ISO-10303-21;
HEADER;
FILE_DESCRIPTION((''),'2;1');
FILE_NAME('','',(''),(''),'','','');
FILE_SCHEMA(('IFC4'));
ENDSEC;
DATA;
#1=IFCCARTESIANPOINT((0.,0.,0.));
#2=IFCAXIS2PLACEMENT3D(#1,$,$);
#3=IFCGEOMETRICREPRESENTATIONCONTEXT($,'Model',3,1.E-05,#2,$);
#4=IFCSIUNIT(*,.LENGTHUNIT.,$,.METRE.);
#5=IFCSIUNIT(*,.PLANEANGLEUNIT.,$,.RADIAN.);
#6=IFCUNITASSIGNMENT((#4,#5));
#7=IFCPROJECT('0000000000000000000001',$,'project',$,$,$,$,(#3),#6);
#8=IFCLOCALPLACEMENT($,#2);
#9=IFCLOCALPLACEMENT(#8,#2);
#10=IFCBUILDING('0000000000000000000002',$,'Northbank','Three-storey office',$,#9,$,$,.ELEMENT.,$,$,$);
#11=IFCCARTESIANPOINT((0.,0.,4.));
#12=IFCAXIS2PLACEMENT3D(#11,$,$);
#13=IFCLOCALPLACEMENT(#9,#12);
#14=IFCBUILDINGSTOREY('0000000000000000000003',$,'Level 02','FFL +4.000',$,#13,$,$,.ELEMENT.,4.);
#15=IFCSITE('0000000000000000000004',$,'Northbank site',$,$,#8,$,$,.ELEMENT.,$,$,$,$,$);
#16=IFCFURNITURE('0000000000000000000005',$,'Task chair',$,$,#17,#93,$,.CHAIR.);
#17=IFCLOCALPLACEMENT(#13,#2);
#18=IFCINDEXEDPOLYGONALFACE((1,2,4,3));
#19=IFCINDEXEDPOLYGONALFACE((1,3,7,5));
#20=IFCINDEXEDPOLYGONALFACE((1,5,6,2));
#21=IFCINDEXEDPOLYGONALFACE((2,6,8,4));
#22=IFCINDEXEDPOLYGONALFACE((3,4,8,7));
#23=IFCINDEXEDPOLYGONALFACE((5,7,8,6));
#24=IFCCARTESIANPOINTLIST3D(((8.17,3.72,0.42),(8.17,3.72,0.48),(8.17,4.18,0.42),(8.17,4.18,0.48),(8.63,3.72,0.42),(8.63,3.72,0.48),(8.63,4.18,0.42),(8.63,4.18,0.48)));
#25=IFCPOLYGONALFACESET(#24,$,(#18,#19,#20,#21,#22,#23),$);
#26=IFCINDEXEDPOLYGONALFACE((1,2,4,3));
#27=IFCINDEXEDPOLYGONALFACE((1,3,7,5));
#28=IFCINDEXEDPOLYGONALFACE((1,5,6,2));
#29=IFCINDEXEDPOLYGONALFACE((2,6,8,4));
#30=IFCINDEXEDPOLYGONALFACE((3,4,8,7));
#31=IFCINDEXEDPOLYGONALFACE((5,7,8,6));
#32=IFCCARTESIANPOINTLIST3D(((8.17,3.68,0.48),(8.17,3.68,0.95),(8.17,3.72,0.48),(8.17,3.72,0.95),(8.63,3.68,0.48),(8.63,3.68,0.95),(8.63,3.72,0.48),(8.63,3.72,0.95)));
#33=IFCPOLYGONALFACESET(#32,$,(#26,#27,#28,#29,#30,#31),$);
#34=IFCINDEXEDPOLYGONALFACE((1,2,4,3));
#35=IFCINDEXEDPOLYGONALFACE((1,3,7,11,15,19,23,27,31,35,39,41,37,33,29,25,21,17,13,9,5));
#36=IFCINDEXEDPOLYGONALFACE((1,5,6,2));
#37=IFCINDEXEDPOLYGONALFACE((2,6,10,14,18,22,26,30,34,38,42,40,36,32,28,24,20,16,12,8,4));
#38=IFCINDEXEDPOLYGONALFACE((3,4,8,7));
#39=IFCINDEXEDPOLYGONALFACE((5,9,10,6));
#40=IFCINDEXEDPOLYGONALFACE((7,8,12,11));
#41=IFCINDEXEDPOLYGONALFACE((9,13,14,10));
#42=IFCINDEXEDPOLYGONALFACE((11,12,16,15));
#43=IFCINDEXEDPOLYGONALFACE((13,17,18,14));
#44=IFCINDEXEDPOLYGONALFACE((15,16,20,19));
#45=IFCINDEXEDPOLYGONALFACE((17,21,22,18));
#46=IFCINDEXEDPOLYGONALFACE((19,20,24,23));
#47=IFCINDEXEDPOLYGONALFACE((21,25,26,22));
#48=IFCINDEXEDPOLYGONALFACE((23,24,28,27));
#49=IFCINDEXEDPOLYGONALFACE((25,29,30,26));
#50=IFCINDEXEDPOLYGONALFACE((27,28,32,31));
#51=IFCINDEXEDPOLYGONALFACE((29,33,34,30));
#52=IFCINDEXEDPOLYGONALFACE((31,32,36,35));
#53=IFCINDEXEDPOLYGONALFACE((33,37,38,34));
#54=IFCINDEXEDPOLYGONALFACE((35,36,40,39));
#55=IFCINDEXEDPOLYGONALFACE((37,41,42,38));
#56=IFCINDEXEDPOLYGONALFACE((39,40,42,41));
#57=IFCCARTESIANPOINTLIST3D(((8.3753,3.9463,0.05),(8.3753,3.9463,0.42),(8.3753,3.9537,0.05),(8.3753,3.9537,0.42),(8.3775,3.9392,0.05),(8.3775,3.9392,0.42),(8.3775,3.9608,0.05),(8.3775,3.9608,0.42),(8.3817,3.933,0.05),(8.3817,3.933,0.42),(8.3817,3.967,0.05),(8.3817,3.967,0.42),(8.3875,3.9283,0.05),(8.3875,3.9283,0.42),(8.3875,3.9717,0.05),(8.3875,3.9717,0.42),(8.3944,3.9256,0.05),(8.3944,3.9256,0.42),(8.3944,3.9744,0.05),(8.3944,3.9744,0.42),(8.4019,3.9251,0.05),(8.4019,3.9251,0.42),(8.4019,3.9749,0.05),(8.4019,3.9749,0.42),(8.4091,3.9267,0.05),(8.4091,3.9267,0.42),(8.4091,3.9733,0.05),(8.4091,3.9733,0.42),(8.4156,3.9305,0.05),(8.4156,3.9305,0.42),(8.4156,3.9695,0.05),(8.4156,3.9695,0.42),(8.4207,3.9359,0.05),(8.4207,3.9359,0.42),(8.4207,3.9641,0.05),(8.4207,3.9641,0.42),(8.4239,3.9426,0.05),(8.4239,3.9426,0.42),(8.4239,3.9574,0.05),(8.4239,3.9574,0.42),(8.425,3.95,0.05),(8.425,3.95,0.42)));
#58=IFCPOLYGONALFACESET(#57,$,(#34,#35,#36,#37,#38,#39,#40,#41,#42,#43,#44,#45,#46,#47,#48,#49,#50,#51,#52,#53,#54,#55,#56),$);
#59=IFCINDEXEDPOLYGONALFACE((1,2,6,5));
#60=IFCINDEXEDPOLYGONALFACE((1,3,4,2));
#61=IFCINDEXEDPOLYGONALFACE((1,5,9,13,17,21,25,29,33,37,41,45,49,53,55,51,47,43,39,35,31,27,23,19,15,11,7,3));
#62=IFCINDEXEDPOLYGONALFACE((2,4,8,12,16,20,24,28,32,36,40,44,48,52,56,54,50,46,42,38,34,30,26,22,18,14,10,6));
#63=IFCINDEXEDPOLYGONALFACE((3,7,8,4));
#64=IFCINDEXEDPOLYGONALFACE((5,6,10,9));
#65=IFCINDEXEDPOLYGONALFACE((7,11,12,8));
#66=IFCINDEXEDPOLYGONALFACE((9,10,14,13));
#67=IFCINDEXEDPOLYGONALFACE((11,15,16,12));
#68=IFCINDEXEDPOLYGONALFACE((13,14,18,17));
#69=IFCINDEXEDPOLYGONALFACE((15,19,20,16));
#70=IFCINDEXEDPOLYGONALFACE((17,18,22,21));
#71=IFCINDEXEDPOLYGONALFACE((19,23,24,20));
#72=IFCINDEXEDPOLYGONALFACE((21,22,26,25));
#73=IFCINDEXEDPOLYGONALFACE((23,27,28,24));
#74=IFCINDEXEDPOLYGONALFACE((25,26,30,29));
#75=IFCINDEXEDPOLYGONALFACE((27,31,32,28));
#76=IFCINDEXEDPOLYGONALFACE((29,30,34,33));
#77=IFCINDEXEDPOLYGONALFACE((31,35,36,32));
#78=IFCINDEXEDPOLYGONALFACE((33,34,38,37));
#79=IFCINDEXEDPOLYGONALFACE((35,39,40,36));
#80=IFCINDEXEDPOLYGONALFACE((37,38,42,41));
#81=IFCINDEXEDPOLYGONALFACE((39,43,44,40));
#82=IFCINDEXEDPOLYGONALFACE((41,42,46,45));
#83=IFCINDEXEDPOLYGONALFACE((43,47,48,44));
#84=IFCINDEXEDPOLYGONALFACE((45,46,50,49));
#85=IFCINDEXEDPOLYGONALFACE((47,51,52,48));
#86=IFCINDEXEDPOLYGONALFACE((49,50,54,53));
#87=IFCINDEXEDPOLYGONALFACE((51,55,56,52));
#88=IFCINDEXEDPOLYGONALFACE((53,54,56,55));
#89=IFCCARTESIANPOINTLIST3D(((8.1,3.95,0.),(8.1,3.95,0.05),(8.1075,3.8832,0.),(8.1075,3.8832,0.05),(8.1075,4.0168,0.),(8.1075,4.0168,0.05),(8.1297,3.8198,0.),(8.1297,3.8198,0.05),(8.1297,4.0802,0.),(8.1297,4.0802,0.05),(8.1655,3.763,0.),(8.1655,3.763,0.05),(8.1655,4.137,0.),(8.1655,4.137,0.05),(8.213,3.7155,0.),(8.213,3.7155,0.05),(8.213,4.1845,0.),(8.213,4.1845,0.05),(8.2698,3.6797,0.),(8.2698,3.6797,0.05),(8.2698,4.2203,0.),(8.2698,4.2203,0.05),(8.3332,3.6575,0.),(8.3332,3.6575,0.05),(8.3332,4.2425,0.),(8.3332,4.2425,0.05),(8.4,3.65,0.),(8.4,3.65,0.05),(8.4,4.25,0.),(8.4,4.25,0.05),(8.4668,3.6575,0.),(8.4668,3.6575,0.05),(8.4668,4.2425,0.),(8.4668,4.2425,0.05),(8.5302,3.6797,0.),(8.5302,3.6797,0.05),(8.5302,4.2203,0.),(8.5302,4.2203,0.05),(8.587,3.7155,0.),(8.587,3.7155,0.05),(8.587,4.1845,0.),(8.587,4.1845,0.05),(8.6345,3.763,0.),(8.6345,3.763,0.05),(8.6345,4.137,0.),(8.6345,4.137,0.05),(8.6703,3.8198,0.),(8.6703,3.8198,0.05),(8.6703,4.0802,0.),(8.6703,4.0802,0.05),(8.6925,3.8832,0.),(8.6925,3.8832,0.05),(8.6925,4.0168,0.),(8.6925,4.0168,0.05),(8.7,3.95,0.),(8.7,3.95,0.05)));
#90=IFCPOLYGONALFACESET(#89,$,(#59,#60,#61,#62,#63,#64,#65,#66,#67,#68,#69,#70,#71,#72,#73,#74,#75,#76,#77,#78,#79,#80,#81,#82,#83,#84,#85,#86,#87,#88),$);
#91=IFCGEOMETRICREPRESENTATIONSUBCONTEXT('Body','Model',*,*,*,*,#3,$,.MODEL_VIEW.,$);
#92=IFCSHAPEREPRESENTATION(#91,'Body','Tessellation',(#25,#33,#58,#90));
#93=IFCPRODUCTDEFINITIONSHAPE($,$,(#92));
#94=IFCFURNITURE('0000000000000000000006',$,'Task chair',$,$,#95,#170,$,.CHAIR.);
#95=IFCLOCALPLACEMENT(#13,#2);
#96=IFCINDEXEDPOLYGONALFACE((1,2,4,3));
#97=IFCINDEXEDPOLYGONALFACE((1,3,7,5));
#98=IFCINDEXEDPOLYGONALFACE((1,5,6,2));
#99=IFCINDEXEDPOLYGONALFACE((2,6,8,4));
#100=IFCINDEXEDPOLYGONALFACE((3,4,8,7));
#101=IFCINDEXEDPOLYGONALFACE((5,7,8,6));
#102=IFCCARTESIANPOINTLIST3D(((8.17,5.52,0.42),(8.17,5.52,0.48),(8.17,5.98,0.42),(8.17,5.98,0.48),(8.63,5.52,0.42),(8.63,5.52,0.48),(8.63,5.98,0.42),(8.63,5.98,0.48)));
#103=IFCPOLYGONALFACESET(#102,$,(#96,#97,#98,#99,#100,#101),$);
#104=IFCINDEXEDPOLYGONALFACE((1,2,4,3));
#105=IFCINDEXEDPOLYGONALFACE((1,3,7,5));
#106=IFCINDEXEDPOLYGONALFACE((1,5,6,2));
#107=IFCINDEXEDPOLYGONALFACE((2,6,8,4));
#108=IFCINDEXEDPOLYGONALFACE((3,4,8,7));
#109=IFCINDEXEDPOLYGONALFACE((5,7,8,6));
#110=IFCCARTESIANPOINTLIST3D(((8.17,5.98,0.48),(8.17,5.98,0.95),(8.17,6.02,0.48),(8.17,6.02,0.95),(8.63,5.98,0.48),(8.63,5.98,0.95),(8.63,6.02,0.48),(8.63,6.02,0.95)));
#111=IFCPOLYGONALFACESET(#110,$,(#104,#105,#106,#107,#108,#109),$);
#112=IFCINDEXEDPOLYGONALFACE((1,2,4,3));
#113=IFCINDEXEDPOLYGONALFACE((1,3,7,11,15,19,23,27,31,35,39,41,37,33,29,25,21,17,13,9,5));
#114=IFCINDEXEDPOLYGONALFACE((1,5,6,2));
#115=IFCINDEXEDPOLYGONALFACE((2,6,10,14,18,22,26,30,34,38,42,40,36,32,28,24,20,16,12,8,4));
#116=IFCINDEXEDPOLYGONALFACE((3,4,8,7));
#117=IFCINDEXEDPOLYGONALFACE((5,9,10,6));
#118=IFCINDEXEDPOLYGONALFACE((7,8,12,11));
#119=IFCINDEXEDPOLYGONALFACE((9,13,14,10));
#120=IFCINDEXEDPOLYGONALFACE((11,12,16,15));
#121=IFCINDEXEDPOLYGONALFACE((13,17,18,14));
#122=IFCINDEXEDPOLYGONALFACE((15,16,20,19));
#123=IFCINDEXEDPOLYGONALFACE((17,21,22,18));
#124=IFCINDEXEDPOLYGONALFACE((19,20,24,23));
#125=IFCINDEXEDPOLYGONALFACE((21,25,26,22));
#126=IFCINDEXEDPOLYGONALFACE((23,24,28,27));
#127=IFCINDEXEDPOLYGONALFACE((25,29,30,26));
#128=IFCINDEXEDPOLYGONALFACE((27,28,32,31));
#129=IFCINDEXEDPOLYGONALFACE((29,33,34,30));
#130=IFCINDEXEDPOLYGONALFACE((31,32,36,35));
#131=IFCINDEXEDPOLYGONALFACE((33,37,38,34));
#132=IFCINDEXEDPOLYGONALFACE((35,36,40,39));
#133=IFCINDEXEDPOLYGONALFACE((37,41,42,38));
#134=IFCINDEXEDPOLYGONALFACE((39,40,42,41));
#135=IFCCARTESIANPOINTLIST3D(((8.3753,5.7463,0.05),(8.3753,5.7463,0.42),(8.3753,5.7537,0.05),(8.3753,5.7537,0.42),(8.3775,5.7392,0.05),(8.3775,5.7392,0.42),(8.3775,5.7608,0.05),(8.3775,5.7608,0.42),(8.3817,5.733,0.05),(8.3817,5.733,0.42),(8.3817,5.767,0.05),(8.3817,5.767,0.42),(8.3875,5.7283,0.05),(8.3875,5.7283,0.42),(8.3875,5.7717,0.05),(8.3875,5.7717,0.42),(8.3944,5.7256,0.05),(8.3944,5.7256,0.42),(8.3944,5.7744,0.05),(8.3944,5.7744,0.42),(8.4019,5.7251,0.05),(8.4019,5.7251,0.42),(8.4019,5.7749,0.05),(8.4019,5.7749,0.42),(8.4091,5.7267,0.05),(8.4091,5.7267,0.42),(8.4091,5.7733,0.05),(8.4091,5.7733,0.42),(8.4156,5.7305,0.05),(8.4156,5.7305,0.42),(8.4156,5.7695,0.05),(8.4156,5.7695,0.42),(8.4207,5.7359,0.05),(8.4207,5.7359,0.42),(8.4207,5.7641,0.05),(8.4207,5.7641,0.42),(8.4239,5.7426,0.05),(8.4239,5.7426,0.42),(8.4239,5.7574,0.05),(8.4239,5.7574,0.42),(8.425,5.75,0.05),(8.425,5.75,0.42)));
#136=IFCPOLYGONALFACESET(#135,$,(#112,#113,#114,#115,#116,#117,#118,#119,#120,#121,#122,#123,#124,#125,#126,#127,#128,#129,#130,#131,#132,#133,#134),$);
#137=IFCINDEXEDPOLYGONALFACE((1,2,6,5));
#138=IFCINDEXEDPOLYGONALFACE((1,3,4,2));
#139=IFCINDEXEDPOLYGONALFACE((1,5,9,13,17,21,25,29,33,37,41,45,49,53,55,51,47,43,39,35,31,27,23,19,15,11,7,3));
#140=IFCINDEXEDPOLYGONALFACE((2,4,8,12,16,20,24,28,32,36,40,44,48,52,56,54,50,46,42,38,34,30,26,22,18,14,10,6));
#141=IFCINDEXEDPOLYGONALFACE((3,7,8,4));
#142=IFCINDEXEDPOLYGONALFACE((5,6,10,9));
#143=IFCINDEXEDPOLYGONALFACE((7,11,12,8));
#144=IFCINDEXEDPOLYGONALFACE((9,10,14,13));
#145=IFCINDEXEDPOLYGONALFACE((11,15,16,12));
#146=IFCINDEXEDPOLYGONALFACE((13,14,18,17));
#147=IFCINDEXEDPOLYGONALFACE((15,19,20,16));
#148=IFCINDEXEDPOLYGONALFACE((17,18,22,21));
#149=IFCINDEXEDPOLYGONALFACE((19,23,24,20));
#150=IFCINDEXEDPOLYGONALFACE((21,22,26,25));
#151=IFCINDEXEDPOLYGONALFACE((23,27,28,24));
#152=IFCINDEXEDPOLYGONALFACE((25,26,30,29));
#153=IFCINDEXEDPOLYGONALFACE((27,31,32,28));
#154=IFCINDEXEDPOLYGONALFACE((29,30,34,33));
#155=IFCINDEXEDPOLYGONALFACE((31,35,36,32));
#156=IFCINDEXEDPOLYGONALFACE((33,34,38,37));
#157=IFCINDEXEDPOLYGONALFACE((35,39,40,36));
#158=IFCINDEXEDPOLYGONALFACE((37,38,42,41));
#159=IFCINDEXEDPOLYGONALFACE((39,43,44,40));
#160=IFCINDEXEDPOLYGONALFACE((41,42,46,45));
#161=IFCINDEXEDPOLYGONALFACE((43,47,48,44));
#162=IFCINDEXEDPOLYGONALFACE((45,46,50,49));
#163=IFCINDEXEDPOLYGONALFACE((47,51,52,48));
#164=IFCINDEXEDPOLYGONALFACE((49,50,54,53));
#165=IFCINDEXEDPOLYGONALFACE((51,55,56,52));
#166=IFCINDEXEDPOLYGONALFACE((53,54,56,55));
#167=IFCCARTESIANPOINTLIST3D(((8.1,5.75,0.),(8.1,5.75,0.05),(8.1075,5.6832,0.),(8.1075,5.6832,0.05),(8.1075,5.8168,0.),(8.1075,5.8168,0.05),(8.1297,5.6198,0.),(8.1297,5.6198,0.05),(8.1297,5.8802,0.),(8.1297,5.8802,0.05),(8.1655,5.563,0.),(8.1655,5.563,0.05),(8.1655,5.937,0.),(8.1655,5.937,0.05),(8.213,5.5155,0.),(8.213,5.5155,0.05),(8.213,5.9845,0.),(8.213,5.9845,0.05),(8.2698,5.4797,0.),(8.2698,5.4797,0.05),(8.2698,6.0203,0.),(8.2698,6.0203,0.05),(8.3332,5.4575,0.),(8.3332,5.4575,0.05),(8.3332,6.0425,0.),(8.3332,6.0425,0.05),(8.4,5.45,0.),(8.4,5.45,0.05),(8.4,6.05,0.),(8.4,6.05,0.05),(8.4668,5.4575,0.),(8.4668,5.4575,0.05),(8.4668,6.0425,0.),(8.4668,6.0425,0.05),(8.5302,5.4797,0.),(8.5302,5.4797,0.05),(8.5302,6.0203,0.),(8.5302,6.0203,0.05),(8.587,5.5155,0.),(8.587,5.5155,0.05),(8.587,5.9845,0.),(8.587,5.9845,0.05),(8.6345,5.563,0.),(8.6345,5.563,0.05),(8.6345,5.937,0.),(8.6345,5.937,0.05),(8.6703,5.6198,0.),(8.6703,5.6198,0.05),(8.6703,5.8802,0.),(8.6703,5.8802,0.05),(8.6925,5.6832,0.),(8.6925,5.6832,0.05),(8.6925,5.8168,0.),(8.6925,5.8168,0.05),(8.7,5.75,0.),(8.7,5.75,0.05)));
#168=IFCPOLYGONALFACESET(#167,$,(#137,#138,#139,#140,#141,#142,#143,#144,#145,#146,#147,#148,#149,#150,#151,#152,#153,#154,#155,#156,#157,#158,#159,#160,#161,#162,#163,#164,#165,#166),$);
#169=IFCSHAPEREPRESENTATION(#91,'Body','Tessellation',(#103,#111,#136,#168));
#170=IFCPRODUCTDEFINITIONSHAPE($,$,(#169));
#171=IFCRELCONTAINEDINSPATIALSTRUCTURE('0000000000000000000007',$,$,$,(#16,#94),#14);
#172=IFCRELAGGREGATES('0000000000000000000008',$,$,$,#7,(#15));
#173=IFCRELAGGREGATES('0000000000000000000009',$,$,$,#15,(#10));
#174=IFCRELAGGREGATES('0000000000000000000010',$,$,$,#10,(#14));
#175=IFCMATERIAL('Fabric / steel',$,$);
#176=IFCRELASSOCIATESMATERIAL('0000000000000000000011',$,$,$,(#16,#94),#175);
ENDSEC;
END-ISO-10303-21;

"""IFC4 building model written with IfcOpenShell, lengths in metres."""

from ifc_helpers import new_model, si_unit, frame, origin, place, context, subcontext, project, spatial, rectangle, circle, extrude, material, element, save


model = new_model("IFC4")

# Units and contexts
model_context = context("Model", 3, precision=1e-05, world=origin())
body_context = subcontext(model_context, "Body", "Model", "MODEL_VIEW")
ifc_project = project(units=[si_unit("LENGTHUNIT", "METRE"), si_unit("PLANEANGLEUNIT", "RADIAN")], contexts=[model_context])

# Site, building, storey
site_placement = place(None, origin())
site = spatial("IfcSite", under=ifc_project, at=site_placement, Name="Northbank site", CompositionType="ELEMENT")
building_placement = place(site_placement, origin())
building = spatial("IfcBuilding", under=site, at=building_placement, Name="Northbank", Description="Three-storey office", CompositionType="ELEMENT")
storey_placement = place(building_placement, frame((0.0, 0.0, 4.0)))
storey = spatial("IfcBuildingStorey", under=building, at=storey_placement, Name="Level 02", Description="FFL +4.000", CompositionType="ELEMENT", Elevation=4.0)

# Furniture
ifc_material_1 = material(Name="Fabric / steel")
furniture_1_placement = place(storey_placement, frame((0.0, 0.0, -4.0)))
element("IfcFurniture", 1, at=furniture_1_placement, inside=storey, material=ifc_material_1, Name="Task chair", PredefinedType="CHAIR", context=body_context, shape_type="SweptSolid", body=[
    extrude(rectangle(XDim=0.46, YDim=0.46), frame((8.4, 3.95, 4.42)), (0.0, 0.0, 1.0), 0.06),
    extrude(rectangle(XDim=0.46, YDim=0.04), frame((8.4, 3.7, 4.48)), (0.0, 0.0, 1.0), 0.47),
    extrude(circle(Radius=0.025), frame((8.4, 3.95, 4.05), z_axis=(0.0, 0.0, 1.0), x_axis=(1.0, 0.0, 0.0)), (0.0, 0.0, 1.0), 0.37),
    extrude(circle(Radius=0.3), frame((8.4, 3.95, 4.0), z_axis=(0.0, 0.0, 1.0), x_axis=(1.0, 0.0, 0.0)), (0.0, 0.0, 1.0), 0.05),
])
furniture_2_placement = place(storey_placement, frame((0.0, 0.0, -4.0)))
element("IfcFurniture", 2, at=furniture_2_placement, inside=storey, material=ifc_material_1, Name="Task chair", PredefinedType="CHAIR", context=body_context, shape_type="SweptSolid", body=[
    extrude(rectangle(XDim=0.46, YDim=0.46), frame((8.4, 5.75, 4.42)), (0.0, 0.0, 1.0), 0.06),
    extrude(rectangle(XDim=0.46, YDim=0.04), frame((8.4, 6.0, 4.48)), (0.0, 0.0, 1.0), 0.47),
    extrude(circle(Radius=0.025), frame((8.4, 5.75, 4.05), z_axis=(0.0, 0.0, 1.0), x_axis=(1.0, 0.0, 0.0)), (0.0, 0.0, 1.0), 0.37),
    extrude(circle(Radius=0.3), frame((8.4, 5.75, 4.0), z_axis=(0.0, 0.0, 1.0), x_axis=(1.0, 0.0, 0.0)), (0.0, 0.0, 1.0), 0.05),
])

save(model, "model.ifc")
